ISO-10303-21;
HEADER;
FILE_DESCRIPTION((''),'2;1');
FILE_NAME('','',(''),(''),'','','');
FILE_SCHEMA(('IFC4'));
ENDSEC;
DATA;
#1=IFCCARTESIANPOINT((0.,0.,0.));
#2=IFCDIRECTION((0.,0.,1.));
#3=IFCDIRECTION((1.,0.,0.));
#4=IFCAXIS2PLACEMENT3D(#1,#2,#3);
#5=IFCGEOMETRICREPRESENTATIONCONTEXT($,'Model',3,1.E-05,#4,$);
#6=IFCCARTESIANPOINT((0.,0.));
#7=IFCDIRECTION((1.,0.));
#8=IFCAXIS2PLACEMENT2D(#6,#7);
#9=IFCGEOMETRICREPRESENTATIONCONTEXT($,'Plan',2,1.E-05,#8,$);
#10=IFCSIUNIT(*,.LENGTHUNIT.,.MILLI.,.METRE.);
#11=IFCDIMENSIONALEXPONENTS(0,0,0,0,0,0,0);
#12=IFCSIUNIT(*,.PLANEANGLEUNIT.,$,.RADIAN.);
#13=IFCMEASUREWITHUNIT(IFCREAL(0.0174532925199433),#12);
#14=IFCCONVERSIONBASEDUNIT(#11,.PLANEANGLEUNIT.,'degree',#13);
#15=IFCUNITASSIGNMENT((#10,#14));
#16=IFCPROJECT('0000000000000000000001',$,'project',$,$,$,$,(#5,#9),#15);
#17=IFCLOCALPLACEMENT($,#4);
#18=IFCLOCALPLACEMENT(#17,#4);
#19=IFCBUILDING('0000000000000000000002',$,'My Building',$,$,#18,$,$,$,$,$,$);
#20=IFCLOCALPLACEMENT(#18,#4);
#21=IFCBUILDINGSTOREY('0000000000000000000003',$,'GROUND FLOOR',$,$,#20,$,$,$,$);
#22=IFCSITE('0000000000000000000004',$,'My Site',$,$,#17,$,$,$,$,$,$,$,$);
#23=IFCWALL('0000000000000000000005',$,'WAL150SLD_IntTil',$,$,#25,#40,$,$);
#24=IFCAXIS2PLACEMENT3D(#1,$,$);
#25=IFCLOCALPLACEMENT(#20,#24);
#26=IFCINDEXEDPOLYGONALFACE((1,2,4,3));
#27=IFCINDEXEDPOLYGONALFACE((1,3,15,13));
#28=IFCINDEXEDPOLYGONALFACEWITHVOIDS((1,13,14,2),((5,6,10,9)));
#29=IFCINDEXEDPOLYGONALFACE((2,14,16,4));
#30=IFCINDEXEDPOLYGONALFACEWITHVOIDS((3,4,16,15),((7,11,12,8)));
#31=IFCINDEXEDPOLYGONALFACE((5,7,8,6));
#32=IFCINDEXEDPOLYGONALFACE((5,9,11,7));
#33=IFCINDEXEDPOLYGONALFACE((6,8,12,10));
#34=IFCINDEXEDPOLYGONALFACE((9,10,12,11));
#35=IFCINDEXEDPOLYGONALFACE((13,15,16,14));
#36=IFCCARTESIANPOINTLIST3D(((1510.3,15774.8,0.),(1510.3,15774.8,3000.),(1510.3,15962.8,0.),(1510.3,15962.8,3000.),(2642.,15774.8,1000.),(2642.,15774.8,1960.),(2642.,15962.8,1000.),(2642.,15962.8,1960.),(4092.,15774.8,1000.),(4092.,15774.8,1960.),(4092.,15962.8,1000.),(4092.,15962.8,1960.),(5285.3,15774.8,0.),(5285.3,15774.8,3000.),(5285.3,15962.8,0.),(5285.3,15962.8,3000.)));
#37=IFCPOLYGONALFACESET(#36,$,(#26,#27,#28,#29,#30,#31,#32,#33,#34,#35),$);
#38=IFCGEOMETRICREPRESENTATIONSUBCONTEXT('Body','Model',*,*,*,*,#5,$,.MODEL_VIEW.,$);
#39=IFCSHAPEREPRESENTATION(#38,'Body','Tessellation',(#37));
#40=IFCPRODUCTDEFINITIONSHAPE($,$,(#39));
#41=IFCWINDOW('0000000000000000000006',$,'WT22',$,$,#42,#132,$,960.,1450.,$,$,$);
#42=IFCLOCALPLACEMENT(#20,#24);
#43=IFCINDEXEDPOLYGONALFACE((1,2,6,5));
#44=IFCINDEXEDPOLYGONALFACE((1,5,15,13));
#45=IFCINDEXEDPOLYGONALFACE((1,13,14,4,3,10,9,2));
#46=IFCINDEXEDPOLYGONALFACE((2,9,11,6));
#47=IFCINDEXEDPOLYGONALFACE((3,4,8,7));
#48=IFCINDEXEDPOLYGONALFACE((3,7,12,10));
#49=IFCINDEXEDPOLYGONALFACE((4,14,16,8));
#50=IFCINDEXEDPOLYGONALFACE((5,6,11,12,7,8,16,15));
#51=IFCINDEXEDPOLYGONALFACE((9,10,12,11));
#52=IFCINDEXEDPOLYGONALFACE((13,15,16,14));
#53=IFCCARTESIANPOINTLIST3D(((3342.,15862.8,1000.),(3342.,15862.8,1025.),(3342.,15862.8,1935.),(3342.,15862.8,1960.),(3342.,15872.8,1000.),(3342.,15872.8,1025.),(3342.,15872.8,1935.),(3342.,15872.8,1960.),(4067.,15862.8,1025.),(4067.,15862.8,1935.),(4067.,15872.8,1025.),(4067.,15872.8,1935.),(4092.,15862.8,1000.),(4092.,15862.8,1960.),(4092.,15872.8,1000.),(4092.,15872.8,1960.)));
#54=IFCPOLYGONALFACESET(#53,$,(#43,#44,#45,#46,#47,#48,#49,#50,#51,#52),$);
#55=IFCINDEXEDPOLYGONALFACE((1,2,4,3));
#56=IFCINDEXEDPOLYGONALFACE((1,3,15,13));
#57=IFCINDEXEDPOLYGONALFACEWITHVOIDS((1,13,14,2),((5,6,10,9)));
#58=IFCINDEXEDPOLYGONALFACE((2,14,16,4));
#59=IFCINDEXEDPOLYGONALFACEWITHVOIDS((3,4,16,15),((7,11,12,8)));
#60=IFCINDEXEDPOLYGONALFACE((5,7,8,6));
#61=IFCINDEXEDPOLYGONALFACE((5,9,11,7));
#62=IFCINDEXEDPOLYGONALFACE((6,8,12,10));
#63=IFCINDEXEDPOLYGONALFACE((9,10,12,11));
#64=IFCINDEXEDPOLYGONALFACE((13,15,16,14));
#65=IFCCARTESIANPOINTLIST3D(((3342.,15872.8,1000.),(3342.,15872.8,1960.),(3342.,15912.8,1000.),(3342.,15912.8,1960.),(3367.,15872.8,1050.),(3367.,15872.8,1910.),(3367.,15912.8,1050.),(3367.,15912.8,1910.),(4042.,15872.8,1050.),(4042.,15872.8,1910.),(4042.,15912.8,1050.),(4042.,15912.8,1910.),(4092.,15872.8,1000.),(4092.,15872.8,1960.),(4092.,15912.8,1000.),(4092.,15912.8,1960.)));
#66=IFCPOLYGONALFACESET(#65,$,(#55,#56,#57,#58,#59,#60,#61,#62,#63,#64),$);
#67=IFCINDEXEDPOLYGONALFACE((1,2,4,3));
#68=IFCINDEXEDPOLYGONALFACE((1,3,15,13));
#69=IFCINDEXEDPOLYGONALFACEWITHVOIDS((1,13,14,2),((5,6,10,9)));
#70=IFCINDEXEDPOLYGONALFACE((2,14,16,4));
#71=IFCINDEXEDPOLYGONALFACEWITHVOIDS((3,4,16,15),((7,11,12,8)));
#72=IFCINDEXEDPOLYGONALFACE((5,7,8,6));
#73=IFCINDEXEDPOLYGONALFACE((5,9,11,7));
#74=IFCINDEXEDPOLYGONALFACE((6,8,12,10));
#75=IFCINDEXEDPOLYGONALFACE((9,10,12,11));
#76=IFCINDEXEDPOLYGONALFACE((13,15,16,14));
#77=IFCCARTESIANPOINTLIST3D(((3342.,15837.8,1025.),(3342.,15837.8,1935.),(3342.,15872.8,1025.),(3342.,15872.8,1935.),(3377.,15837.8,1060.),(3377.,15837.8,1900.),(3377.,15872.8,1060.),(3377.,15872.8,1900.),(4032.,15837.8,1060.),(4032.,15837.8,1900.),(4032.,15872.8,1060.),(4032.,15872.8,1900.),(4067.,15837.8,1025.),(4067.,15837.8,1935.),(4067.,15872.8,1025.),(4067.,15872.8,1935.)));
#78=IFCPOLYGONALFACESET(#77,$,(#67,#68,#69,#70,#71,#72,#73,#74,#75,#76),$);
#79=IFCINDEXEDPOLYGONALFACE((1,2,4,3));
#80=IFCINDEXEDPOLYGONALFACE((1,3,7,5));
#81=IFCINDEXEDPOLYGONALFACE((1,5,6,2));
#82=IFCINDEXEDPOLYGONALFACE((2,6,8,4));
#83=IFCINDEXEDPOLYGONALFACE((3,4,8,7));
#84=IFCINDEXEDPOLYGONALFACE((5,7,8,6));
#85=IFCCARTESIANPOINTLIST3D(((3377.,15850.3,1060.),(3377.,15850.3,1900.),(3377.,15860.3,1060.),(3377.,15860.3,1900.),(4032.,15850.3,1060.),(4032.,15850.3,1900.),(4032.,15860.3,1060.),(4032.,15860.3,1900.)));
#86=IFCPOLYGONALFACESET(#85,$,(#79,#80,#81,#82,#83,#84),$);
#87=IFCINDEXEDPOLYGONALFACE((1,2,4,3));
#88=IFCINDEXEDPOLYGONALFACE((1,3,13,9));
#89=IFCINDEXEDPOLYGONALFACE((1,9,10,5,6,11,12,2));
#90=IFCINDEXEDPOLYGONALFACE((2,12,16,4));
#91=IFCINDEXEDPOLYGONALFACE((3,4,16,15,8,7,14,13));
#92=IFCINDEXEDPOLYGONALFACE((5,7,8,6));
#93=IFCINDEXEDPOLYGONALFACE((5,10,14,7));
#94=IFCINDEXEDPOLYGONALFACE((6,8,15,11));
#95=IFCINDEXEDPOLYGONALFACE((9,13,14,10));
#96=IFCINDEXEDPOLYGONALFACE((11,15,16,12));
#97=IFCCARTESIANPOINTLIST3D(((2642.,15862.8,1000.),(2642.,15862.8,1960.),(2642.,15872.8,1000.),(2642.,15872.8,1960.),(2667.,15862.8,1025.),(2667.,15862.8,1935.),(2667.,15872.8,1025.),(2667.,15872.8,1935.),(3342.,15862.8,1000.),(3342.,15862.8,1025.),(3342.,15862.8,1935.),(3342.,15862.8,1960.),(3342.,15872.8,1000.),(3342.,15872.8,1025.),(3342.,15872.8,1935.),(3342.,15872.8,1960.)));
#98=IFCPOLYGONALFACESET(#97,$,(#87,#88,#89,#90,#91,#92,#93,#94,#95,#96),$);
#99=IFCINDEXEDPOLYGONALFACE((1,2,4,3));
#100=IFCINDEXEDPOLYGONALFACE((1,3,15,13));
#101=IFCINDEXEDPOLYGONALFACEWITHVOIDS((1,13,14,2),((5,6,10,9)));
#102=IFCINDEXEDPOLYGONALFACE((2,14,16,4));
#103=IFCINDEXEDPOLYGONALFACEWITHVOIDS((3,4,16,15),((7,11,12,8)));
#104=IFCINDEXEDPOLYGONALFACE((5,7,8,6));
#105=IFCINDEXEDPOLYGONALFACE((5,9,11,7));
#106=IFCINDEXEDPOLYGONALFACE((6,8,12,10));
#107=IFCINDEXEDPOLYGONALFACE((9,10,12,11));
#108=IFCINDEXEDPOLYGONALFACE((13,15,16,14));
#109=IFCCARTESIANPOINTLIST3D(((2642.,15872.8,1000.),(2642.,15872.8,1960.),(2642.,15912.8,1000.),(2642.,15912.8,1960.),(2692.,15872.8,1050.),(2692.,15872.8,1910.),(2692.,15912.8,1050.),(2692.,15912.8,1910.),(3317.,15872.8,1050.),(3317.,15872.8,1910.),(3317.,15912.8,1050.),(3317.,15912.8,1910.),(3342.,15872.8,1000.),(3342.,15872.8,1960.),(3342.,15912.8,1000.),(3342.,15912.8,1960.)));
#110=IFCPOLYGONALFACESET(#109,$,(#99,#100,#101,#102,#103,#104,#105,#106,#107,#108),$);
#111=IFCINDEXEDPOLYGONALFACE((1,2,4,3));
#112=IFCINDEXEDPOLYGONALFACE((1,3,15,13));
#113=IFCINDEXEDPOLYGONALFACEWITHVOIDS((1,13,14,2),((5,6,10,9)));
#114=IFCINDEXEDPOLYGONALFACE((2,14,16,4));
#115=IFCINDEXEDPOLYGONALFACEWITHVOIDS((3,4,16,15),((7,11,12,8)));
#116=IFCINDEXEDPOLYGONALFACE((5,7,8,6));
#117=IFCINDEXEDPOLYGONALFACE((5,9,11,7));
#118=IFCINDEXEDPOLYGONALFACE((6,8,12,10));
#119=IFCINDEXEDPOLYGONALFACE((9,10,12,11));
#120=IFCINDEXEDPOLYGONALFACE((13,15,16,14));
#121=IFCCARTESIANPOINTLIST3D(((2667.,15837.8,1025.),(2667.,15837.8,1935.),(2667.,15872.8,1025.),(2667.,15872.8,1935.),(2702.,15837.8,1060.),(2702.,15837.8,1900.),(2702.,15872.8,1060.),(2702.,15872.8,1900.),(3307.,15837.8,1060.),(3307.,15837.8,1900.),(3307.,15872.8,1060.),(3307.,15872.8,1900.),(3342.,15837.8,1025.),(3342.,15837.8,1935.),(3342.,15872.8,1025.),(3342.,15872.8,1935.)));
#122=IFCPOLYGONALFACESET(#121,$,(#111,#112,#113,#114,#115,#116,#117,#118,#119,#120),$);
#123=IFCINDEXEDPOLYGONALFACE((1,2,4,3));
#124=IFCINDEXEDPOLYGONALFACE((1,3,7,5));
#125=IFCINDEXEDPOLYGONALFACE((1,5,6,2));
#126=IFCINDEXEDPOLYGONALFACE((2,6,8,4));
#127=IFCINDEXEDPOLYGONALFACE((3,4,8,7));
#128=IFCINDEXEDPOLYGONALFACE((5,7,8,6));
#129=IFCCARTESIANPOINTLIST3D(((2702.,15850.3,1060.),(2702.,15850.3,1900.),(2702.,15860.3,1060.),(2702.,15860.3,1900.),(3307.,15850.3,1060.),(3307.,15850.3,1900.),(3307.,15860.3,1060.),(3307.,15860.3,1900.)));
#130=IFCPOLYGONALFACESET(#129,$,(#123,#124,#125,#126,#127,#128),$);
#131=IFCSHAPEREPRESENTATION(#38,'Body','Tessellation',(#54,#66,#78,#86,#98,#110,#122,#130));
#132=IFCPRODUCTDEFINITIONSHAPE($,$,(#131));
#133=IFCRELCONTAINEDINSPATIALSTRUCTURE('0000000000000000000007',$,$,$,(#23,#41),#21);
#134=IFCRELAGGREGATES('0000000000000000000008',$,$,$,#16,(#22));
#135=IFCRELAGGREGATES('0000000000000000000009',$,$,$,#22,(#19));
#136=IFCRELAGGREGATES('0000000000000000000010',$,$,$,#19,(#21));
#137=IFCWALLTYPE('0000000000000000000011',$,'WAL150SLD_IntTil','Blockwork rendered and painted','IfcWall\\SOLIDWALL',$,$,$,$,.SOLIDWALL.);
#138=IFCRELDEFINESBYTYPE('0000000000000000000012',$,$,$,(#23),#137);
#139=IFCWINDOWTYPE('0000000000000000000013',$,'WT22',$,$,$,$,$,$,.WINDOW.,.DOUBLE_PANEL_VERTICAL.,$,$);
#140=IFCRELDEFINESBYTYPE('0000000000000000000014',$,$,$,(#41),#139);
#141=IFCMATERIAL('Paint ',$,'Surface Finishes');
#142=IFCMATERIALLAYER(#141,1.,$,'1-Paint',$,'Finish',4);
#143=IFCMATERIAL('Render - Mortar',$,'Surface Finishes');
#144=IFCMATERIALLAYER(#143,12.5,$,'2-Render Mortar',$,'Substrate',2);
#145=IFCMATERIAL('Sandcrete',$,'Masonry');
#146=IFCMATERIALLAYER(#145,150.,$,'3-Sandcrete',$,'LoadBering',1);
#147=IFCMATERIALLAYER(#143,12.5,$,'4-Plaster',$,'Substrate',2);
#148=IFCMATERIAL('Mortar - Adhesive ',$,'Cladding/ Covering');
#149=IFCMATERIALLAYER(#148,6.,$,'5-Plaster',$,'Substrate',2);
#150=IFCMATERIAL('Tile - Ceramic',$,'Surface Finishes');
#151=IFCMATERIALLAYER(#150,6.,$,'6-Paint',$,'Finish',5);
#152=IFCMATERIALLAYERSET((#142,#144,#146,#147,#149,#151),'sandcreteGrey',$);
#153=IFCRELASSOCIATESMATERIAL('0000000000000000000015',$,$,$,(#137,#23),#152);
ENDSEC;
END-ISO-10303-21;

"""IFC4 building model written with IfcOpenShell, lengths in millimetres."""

from ifc_helpers import new_model, entity, si_unit, converted_unit, frame, origin_with_axes, origin_2d_with_axis, place, context, subcontext, project, spatial, line, indexed_curve, outline, extrude, shape, source, transform, mapped, material, layer, layer_set, layer_usage, type_object, type_shapes, element, fill, save


model = new_model("IFC4")

# Units and contexts
model_context = context("Model", 3, precision=1e-05, world=origin_with_axes())
plan_context = context("Plan", 2, precision=1e-05, world=origin_2d_with_axis())
body_context_1 = subcontext(model_context, "Body", "Model", "MODEL_VIEW")
body_context_2 = subcontext(plan_context, "Body", "Plan", "PLAN_VIEW")
ifc_project = project(units=[si_unit("LENGTHUNIT", "METRE", prefix="MILLI"), converted_unit("PLANEANGLEUNIT", "degree", entity("IfcReal", 0.0174532925199433), si_unit("PLANEANGLEUNIT", "RADIAN"), dimensions=[0, 0, 0, 0, 0, 0, 0])], contexts=[model_context, plan_context])

# Site, building, storey
site_placement = place(None, origin_with_axes())
site = spatial("IfcSite", under=ifc_project, at=site_placement, Name="My Site")
building_placement = place(site_placement, origin_with_axes())
building = spatial("IfcBuilding", under=site, at=building_placement, Name="My Building")
storey_placement = place(building_placement, origin_with_axes())
storey = spatial("IfcBuildingStorey", under=building, at=storey_placement, Name="GROUND FLOOR")

# Shared definitions
ifc_material_1 = material(Name="Paint ", Category="Surface Finishes")
ifc_material_2 = material(Name="Render - Mortar", Category="Surface Finishes")
ifc_material_3 = material(Name="Sandcrete", Category="Masonry")

# Shared definitions
ifc_material_4 = material(Name="Mortar - Adhesive ", Category="Cladding/ Covering")
ifc_material_5 = material(Name="Tile - Ceramic", Category="Surface Finishes")

# Wall, opening, window
ifc_layer_1 = layer(ifc_material_1, 1.0, Name="1-Paint", Category="Finish", Priority=4)
ifc_layer_2 = layer(ifc_material_2, 12.5, Name="2-Render Mortar", Category="Substrate", Priority=2)
ifc_layer_3 = layer(ifc_material_3, 150.0, Name="3-Sandcrete", Category="LoadBering", Priority=1)
ifc_layer_4 = layer(ifc_material_2, 12.5, Name="4-Plaster", Category="Substrate", Priority=2)
ifc_layer_5 = layer(ifc_material_4, 6.0, Name="5-Plaster", Category="Substrate", Priority=2)
ifc_layer_6 = layer(ifc_material_5, 6.0, Name="6-Paint", Category="Finish", Priority=5)
ifc_layer_set_1 = layer_set([ifc_layer_1, ifc_layer_2, ifc_layer_3, ifc_layer_4, ifc_layer_5, ifc_layer_6], Name="sandcreteGrey")
ifc_layer_usage_1 = layer_usage(ifc_layer_set_1, "AXIS2", "POSITIVE", 0.0)
wall_type_1 = type_object("IfcWallType", Name="WAL150SLD_IntTil", Description="Blockwork rendered and painted", ApplicableOccurrence="IfcWall\\SOLIDWALL", PredefinedType="SOLIDWALL", material=ifc_layer_set_1)
wall_1_placement = place(storey_placement, frame((5285.3, 15962.8, 0.0), z_axis=(0.0, 0.0, 1.0), x_axis=(-1.0, 0.000001, 0.0)))
wall_1 = element("IfcWall", 1, at=wall_1_placement, inside=storey, type_object=wall_type_1, material=ifc_layer_usage_1, Name="WAL150SLD_IntTil", context=body_context_1, shape_type="SweptSolid", body=[
    extrude(outline(indexed_curve([(0.0, 0.0), (0.0, 188.0), (3775.0, 188.0), (3775.0, 0.0), (0.0, 0.0)], self_intersect=False)), origin_with_axes(), (0.0, 0.0, 1.0), 3000.0),
])
shared_shape_1 = source(origin_with_axes(), body_context_1, "Body", "SweptSolid", [
    extrude(outline(indexed_curve([(0.0, 0.0), (1450.0, 0.0), (1450.0, 960.0), (0.0, 960.0)], segments=[line(1, 2, 3, 4, 1)])), frame((0.0, -600.0, 0.0), z_axis=(0.0, -1.0, 0.0), x_axis=(1.0, 0.0, 0.0)), (0.0, 0.0, -1.0), 1200.0),
])
opening_1_placement = place(wall_1_placement, frame((1193.3, 0.0, 1000.0), z_axis=(0.0, 0.0, 1.0), x_axis=(1.0, 0.0, 0.0)))
opening_1 = element("IfcOpeningElement", 2, at=opening_1_placement, cuts=wall_1, PredefinedType="OPENING", context=body_context_1, shape_type="MappedRepresentation", body=[
    mapped(shared_shape_1, transform((0.0, 0.0, 0.0), x_axis=(1.0, 0.0, 0.0), y_axis=(0.0, 1.0, 0.0), z_axis=(0.0, 0.0, 1.0), scale=1.0)),
])
window_type_1 = type_object("IfcWindowType", Name="WT22", PartitioningType="DOUBLE_PANEL_VERTICAL", PredefinedType="WINDOW")
shared_shape_2 = source(origin_with_axes(), body_context_1, "Body", "SweptSolid", [
    extrude(outline(indexed_curve([(750.0, 0.0), (0.0, 0.0), (0.0, 960.0), (750.0, 960.0), (750.0, 935.0), (25.0, 935.0), (25.0, 25.0), (750.0, 25.0)], segments=[line(1, 2, 3, 4, 5, 6, 7, 8, 1)])), frame((0.0, 90.0, 0.0), z_axis=(0.0, -1.0, 0.0), x_axis=(1.0, 0.0, 0.0)), (0.0, 0.0, -1.0), 10.0),
    extrude(outline(indexed_curve([(0.0, 0.0), (750.0, 0.0), (750.0, 960.0), (0.0, 960.0)], segments=[line(1, 2, 3, 4, 1)]), holes=[indexed_curve([(50.0, 50.0), (725.0, 50.0), (725.0, 910.0), (50.0, 910.0)], segments=[line(1, 2, 3, 4, 1)])]), frame((0.0, 50.0, 0.0), z_axis=(0.0, -1.0, 0.0), x_axis=(1.0, 0.0, 0.0)), (0.0, 0.0, -1.0), 40.0),
    extrude(outline(indexed_curve([(0.0, 0.0), (725.0, 0.0), (725.0, 910.0), (0.0, 910.0)], segments=[line(1, 2, 3, 4, 1)]), holes=[indexed_curve([(35.0, 35.0), (690.0, 35.0), (690.0, 875.0), (35.0, 875.0)], segments=[line(1, 2, 3, 4, 1)])]), frame((25.0, 90.0, 25.0), z_axis=(0.0, -1.0, 0.0), x_axis=(1.0, 0.0, 0.0)), (0.0, 0.0, -1.0), 35.0),
    extrude(outline(indexed_curve([(35.0, 35.0), (690.0, 35.0), (690.0, 875.0), (35.0, 875.0)], segments=[line(1, 2, 3, 4, 1)])), frame((25.0, 102.5, 25.0), z_axis=(0.0, -1.0, 0.0), x_axis=(1.0, 0.0, 0.0)), (0.0, 0.0, -1.0), 10.0),
    extrude(outline(indexed_curve([(0.0, 960.0), (700.0, 960.0), (700.0, 0.0), (0.0, 0.0), (0.0, 25.0), (675.0, 25.0), (675.0, 935.0), (0.0, 935.0)], segments=[line(1, 2, 3, 4, 5, 6, 7, 8, 1)])), frame((750.0, 90.0, 0.0), z_axis=(0.0, -1.0, 0.0), x_axis=(1.0, 0.0, 0.0)), (0.0, 0.0, -1.0), 10.0),
    extrude(outline(indexed_curve([(0.0, 0.0), (700.0, 0.0), (700.0, 960.0), (0.0, 960.0)], segments=[line(1, 2, 3, 4, 1)]), holes=[indexed_curve([(25.0, 50.0), (650.0, 50.0), (650.0, 910.0), (25.0, 910.0)], segments=[line(1, 2, 3, 4, 1)])]), frame((750.0, 50.0, 0.0), z_axis=(0.0, -1.0, 0.0), x_axis=(1.0, 0.0, 0.0)), (0.0, 0.0, -1.0), 40.0),
    extrude(outline(indexed_curve([(0.0, 0.0), (675.0, 0.0), (675.0, 910.0), (0.0, 910.0)], segments=[line(1, 2, 3, 4, 1)]), holes=[indexed_curve([(35.0, 35.0), (640.0, 35.0), (640.0, 875.0), (35.0, 875.0)], segments=[line(1, 2, 3, 4, 1)])]), frame((750.0, 90.0, 25.0), z_axis=(0.0, -1.0, 0.0), x_axis=(1.0, 0.0, 0.0)), (0.0, 0.0, -1.0), 35.0),
    extrude(outline(indexed_curve([(35.0, 35.0), (640.0, 35.0), (640.0, 875.0), (35.0, 875.0)], segments=[line(1, 2, 3, 4, 1)])), frame((750.0, 102.5, 25.0), z_axis=(0.0, -1.0, 0.0), x_axis=(1.0, 0.0, 0.0)), (0.0, 0.0, -1.0), 10.0),
])
shared_shape_3 = source(origin_with_axes(), body_context_2, "Body", "Curve2D", [
    entity("IfcIndexedPolyCurve", entity("IfcCartesianPointList2D", [[50.0, 50.0], [725.0, 50.0]])),
    entity("IfcIndexedPolyCurve", entity("IfcCartesianPointList2D", [[0.0, 100.0], [25.0, 100.0], [25.0, 90.0], [50.0, 90.0], [50.0, 50.0], [0.0, 50.0]]), [entity("IfcLineIndex", [1, 2, 3, 4, 5, 6, 1])]),
    entity("IfcIndexedPolyCurve", entity("IfcCartesianPointList2D", [[750.0, 100.0], [750.0, 100.0], [750.0, 90.0], [725.0, 90.0], [725.0, 50.0], [750.0, 50.0]])),
    entity("IfcIndexedPolyCurve", entity("IfcCartesianPointList2D", [[25.0, 90.0], [60.0, 90.0], [60.0, 125.0], [25.0, 125.0]]), [entity("IfcLineIndex", [1, 2, 3, 4, 1])]),
    entity("IfcIndexedPolyCurve", entity("IfcCartesianPointList2D", [[750.0, 90.0], [715.0, 90.0], [715.0, 125.0], [750.0, 125.0]]), [entity("IfcLineIndex", [1, 2, 3, 4, 1])]),
    entity("IfcIndexedPolyCurve", entity("IfcCartesianPointList2D", [[60.0, 90.0], [715.0, 90.0]])),
    entity("IfcIndexedPolyCurve", entity("IfcCartesianPointList2D", [[60.0, 125.0], [715.0, 125.0]])),
    entity("IfcIndexedPolyCurve", entity("IfcCartesianPointList2D", [[60.0, 107.5], [715.0, 107.5]])),
    entity("IfcIndexedPolyCurve", entity("IfcCartesianPointList2D", [[775.0, 50.0], [1400.0, 50.0]])),
    entity("IfcIndexedPolyCurve", entity("IfcCartesianPointList2D", [[750.0, 100.0], [750.0, 100.0], [750.0, 90.0], [775.0, 90.0], [775.0, 50.0], [750.0, 50.0]])),
    entity("IfcIndexedPolyCurve", entity("IfcCartesianPointList2D", [[1450.0, 100.0], [1425.0, 100.0], [1425.0, 90.0], [1400.0, 90.0], [1400.0, 50.0], [1450.0, 50.0]]), [entity("IfcLineIndex", [1, 2, 3, 4, 5, 6, 1])]),
    entity("IfcIndexedPolyCurve", entity("IfcCartesianPointList2D", [[750.0, 90.0], [785.0, 90.0], [785.0, 125.0], [750.0, 125.0]]), [entity("IfcLineIndex", [1, 2, 3, 4, 1])]),
    entity("IfcIndexedPolyCurve", entity("IfcCartesianPointList2D", [[1425.0, 90.0], [1390.0, 90.0], [1390.0, 125.0], [1425.0, 125.0]]), [entity("IfcLineIndex", [1, 2, 3, 4, 1])]),
    entity("IfcIndexedPolyCurve", entity("IfcCartesianPointList2D", [[785.0, 90.0], [1390.0, 90.0]])),
    entity("IfcIndexedPolyCurve", entity("IfcCartesianPointList2D", [[785.0, 125.0], [1390.0, 125.0]])),
    entity("IfcIndexedPolyCurve", entity("IfcCartesianPointList2D", [[785.0, 107.5], [1390.0, 107.5]])),
])
type_shapes(window_type_1, [shared_shape_2, shared_shape_3])
window_1_placement = place(opening_1_placement, origin_with_axes())
window_1 = element("IfcWindow", 3, at=window_1_placement, inside=storey, type_object=window_type_1, Name="WT22", OverallHeight=960.0, OverallWidth=1450.0, shapes=[
    shape(body_context_1, "Body", "MappedRepresentation", [mapped(shared_shape_2, transform((0.0, 0.0, 0.0), x_axis=(1.0, 0.0, 0.0), y_axis=(0.0, 1.0, 0.0), z_axis=(0.0, 0.0, 1.0), scale=1.0))]),
    shape(body_context_2, "Body", "MappedRepresentation", [mapped(shared_shape_3, transform((0.0, 0.0, 0.0), x_axis=(1.0, 0.0, 0.0), y_axis=(0.0, 1.0, 0.0), z_axis=(0.0, 0.0, 1.0), scale=1.0))]),
])
fill(opening_1, window_1)

save(model, "model.ifc")
